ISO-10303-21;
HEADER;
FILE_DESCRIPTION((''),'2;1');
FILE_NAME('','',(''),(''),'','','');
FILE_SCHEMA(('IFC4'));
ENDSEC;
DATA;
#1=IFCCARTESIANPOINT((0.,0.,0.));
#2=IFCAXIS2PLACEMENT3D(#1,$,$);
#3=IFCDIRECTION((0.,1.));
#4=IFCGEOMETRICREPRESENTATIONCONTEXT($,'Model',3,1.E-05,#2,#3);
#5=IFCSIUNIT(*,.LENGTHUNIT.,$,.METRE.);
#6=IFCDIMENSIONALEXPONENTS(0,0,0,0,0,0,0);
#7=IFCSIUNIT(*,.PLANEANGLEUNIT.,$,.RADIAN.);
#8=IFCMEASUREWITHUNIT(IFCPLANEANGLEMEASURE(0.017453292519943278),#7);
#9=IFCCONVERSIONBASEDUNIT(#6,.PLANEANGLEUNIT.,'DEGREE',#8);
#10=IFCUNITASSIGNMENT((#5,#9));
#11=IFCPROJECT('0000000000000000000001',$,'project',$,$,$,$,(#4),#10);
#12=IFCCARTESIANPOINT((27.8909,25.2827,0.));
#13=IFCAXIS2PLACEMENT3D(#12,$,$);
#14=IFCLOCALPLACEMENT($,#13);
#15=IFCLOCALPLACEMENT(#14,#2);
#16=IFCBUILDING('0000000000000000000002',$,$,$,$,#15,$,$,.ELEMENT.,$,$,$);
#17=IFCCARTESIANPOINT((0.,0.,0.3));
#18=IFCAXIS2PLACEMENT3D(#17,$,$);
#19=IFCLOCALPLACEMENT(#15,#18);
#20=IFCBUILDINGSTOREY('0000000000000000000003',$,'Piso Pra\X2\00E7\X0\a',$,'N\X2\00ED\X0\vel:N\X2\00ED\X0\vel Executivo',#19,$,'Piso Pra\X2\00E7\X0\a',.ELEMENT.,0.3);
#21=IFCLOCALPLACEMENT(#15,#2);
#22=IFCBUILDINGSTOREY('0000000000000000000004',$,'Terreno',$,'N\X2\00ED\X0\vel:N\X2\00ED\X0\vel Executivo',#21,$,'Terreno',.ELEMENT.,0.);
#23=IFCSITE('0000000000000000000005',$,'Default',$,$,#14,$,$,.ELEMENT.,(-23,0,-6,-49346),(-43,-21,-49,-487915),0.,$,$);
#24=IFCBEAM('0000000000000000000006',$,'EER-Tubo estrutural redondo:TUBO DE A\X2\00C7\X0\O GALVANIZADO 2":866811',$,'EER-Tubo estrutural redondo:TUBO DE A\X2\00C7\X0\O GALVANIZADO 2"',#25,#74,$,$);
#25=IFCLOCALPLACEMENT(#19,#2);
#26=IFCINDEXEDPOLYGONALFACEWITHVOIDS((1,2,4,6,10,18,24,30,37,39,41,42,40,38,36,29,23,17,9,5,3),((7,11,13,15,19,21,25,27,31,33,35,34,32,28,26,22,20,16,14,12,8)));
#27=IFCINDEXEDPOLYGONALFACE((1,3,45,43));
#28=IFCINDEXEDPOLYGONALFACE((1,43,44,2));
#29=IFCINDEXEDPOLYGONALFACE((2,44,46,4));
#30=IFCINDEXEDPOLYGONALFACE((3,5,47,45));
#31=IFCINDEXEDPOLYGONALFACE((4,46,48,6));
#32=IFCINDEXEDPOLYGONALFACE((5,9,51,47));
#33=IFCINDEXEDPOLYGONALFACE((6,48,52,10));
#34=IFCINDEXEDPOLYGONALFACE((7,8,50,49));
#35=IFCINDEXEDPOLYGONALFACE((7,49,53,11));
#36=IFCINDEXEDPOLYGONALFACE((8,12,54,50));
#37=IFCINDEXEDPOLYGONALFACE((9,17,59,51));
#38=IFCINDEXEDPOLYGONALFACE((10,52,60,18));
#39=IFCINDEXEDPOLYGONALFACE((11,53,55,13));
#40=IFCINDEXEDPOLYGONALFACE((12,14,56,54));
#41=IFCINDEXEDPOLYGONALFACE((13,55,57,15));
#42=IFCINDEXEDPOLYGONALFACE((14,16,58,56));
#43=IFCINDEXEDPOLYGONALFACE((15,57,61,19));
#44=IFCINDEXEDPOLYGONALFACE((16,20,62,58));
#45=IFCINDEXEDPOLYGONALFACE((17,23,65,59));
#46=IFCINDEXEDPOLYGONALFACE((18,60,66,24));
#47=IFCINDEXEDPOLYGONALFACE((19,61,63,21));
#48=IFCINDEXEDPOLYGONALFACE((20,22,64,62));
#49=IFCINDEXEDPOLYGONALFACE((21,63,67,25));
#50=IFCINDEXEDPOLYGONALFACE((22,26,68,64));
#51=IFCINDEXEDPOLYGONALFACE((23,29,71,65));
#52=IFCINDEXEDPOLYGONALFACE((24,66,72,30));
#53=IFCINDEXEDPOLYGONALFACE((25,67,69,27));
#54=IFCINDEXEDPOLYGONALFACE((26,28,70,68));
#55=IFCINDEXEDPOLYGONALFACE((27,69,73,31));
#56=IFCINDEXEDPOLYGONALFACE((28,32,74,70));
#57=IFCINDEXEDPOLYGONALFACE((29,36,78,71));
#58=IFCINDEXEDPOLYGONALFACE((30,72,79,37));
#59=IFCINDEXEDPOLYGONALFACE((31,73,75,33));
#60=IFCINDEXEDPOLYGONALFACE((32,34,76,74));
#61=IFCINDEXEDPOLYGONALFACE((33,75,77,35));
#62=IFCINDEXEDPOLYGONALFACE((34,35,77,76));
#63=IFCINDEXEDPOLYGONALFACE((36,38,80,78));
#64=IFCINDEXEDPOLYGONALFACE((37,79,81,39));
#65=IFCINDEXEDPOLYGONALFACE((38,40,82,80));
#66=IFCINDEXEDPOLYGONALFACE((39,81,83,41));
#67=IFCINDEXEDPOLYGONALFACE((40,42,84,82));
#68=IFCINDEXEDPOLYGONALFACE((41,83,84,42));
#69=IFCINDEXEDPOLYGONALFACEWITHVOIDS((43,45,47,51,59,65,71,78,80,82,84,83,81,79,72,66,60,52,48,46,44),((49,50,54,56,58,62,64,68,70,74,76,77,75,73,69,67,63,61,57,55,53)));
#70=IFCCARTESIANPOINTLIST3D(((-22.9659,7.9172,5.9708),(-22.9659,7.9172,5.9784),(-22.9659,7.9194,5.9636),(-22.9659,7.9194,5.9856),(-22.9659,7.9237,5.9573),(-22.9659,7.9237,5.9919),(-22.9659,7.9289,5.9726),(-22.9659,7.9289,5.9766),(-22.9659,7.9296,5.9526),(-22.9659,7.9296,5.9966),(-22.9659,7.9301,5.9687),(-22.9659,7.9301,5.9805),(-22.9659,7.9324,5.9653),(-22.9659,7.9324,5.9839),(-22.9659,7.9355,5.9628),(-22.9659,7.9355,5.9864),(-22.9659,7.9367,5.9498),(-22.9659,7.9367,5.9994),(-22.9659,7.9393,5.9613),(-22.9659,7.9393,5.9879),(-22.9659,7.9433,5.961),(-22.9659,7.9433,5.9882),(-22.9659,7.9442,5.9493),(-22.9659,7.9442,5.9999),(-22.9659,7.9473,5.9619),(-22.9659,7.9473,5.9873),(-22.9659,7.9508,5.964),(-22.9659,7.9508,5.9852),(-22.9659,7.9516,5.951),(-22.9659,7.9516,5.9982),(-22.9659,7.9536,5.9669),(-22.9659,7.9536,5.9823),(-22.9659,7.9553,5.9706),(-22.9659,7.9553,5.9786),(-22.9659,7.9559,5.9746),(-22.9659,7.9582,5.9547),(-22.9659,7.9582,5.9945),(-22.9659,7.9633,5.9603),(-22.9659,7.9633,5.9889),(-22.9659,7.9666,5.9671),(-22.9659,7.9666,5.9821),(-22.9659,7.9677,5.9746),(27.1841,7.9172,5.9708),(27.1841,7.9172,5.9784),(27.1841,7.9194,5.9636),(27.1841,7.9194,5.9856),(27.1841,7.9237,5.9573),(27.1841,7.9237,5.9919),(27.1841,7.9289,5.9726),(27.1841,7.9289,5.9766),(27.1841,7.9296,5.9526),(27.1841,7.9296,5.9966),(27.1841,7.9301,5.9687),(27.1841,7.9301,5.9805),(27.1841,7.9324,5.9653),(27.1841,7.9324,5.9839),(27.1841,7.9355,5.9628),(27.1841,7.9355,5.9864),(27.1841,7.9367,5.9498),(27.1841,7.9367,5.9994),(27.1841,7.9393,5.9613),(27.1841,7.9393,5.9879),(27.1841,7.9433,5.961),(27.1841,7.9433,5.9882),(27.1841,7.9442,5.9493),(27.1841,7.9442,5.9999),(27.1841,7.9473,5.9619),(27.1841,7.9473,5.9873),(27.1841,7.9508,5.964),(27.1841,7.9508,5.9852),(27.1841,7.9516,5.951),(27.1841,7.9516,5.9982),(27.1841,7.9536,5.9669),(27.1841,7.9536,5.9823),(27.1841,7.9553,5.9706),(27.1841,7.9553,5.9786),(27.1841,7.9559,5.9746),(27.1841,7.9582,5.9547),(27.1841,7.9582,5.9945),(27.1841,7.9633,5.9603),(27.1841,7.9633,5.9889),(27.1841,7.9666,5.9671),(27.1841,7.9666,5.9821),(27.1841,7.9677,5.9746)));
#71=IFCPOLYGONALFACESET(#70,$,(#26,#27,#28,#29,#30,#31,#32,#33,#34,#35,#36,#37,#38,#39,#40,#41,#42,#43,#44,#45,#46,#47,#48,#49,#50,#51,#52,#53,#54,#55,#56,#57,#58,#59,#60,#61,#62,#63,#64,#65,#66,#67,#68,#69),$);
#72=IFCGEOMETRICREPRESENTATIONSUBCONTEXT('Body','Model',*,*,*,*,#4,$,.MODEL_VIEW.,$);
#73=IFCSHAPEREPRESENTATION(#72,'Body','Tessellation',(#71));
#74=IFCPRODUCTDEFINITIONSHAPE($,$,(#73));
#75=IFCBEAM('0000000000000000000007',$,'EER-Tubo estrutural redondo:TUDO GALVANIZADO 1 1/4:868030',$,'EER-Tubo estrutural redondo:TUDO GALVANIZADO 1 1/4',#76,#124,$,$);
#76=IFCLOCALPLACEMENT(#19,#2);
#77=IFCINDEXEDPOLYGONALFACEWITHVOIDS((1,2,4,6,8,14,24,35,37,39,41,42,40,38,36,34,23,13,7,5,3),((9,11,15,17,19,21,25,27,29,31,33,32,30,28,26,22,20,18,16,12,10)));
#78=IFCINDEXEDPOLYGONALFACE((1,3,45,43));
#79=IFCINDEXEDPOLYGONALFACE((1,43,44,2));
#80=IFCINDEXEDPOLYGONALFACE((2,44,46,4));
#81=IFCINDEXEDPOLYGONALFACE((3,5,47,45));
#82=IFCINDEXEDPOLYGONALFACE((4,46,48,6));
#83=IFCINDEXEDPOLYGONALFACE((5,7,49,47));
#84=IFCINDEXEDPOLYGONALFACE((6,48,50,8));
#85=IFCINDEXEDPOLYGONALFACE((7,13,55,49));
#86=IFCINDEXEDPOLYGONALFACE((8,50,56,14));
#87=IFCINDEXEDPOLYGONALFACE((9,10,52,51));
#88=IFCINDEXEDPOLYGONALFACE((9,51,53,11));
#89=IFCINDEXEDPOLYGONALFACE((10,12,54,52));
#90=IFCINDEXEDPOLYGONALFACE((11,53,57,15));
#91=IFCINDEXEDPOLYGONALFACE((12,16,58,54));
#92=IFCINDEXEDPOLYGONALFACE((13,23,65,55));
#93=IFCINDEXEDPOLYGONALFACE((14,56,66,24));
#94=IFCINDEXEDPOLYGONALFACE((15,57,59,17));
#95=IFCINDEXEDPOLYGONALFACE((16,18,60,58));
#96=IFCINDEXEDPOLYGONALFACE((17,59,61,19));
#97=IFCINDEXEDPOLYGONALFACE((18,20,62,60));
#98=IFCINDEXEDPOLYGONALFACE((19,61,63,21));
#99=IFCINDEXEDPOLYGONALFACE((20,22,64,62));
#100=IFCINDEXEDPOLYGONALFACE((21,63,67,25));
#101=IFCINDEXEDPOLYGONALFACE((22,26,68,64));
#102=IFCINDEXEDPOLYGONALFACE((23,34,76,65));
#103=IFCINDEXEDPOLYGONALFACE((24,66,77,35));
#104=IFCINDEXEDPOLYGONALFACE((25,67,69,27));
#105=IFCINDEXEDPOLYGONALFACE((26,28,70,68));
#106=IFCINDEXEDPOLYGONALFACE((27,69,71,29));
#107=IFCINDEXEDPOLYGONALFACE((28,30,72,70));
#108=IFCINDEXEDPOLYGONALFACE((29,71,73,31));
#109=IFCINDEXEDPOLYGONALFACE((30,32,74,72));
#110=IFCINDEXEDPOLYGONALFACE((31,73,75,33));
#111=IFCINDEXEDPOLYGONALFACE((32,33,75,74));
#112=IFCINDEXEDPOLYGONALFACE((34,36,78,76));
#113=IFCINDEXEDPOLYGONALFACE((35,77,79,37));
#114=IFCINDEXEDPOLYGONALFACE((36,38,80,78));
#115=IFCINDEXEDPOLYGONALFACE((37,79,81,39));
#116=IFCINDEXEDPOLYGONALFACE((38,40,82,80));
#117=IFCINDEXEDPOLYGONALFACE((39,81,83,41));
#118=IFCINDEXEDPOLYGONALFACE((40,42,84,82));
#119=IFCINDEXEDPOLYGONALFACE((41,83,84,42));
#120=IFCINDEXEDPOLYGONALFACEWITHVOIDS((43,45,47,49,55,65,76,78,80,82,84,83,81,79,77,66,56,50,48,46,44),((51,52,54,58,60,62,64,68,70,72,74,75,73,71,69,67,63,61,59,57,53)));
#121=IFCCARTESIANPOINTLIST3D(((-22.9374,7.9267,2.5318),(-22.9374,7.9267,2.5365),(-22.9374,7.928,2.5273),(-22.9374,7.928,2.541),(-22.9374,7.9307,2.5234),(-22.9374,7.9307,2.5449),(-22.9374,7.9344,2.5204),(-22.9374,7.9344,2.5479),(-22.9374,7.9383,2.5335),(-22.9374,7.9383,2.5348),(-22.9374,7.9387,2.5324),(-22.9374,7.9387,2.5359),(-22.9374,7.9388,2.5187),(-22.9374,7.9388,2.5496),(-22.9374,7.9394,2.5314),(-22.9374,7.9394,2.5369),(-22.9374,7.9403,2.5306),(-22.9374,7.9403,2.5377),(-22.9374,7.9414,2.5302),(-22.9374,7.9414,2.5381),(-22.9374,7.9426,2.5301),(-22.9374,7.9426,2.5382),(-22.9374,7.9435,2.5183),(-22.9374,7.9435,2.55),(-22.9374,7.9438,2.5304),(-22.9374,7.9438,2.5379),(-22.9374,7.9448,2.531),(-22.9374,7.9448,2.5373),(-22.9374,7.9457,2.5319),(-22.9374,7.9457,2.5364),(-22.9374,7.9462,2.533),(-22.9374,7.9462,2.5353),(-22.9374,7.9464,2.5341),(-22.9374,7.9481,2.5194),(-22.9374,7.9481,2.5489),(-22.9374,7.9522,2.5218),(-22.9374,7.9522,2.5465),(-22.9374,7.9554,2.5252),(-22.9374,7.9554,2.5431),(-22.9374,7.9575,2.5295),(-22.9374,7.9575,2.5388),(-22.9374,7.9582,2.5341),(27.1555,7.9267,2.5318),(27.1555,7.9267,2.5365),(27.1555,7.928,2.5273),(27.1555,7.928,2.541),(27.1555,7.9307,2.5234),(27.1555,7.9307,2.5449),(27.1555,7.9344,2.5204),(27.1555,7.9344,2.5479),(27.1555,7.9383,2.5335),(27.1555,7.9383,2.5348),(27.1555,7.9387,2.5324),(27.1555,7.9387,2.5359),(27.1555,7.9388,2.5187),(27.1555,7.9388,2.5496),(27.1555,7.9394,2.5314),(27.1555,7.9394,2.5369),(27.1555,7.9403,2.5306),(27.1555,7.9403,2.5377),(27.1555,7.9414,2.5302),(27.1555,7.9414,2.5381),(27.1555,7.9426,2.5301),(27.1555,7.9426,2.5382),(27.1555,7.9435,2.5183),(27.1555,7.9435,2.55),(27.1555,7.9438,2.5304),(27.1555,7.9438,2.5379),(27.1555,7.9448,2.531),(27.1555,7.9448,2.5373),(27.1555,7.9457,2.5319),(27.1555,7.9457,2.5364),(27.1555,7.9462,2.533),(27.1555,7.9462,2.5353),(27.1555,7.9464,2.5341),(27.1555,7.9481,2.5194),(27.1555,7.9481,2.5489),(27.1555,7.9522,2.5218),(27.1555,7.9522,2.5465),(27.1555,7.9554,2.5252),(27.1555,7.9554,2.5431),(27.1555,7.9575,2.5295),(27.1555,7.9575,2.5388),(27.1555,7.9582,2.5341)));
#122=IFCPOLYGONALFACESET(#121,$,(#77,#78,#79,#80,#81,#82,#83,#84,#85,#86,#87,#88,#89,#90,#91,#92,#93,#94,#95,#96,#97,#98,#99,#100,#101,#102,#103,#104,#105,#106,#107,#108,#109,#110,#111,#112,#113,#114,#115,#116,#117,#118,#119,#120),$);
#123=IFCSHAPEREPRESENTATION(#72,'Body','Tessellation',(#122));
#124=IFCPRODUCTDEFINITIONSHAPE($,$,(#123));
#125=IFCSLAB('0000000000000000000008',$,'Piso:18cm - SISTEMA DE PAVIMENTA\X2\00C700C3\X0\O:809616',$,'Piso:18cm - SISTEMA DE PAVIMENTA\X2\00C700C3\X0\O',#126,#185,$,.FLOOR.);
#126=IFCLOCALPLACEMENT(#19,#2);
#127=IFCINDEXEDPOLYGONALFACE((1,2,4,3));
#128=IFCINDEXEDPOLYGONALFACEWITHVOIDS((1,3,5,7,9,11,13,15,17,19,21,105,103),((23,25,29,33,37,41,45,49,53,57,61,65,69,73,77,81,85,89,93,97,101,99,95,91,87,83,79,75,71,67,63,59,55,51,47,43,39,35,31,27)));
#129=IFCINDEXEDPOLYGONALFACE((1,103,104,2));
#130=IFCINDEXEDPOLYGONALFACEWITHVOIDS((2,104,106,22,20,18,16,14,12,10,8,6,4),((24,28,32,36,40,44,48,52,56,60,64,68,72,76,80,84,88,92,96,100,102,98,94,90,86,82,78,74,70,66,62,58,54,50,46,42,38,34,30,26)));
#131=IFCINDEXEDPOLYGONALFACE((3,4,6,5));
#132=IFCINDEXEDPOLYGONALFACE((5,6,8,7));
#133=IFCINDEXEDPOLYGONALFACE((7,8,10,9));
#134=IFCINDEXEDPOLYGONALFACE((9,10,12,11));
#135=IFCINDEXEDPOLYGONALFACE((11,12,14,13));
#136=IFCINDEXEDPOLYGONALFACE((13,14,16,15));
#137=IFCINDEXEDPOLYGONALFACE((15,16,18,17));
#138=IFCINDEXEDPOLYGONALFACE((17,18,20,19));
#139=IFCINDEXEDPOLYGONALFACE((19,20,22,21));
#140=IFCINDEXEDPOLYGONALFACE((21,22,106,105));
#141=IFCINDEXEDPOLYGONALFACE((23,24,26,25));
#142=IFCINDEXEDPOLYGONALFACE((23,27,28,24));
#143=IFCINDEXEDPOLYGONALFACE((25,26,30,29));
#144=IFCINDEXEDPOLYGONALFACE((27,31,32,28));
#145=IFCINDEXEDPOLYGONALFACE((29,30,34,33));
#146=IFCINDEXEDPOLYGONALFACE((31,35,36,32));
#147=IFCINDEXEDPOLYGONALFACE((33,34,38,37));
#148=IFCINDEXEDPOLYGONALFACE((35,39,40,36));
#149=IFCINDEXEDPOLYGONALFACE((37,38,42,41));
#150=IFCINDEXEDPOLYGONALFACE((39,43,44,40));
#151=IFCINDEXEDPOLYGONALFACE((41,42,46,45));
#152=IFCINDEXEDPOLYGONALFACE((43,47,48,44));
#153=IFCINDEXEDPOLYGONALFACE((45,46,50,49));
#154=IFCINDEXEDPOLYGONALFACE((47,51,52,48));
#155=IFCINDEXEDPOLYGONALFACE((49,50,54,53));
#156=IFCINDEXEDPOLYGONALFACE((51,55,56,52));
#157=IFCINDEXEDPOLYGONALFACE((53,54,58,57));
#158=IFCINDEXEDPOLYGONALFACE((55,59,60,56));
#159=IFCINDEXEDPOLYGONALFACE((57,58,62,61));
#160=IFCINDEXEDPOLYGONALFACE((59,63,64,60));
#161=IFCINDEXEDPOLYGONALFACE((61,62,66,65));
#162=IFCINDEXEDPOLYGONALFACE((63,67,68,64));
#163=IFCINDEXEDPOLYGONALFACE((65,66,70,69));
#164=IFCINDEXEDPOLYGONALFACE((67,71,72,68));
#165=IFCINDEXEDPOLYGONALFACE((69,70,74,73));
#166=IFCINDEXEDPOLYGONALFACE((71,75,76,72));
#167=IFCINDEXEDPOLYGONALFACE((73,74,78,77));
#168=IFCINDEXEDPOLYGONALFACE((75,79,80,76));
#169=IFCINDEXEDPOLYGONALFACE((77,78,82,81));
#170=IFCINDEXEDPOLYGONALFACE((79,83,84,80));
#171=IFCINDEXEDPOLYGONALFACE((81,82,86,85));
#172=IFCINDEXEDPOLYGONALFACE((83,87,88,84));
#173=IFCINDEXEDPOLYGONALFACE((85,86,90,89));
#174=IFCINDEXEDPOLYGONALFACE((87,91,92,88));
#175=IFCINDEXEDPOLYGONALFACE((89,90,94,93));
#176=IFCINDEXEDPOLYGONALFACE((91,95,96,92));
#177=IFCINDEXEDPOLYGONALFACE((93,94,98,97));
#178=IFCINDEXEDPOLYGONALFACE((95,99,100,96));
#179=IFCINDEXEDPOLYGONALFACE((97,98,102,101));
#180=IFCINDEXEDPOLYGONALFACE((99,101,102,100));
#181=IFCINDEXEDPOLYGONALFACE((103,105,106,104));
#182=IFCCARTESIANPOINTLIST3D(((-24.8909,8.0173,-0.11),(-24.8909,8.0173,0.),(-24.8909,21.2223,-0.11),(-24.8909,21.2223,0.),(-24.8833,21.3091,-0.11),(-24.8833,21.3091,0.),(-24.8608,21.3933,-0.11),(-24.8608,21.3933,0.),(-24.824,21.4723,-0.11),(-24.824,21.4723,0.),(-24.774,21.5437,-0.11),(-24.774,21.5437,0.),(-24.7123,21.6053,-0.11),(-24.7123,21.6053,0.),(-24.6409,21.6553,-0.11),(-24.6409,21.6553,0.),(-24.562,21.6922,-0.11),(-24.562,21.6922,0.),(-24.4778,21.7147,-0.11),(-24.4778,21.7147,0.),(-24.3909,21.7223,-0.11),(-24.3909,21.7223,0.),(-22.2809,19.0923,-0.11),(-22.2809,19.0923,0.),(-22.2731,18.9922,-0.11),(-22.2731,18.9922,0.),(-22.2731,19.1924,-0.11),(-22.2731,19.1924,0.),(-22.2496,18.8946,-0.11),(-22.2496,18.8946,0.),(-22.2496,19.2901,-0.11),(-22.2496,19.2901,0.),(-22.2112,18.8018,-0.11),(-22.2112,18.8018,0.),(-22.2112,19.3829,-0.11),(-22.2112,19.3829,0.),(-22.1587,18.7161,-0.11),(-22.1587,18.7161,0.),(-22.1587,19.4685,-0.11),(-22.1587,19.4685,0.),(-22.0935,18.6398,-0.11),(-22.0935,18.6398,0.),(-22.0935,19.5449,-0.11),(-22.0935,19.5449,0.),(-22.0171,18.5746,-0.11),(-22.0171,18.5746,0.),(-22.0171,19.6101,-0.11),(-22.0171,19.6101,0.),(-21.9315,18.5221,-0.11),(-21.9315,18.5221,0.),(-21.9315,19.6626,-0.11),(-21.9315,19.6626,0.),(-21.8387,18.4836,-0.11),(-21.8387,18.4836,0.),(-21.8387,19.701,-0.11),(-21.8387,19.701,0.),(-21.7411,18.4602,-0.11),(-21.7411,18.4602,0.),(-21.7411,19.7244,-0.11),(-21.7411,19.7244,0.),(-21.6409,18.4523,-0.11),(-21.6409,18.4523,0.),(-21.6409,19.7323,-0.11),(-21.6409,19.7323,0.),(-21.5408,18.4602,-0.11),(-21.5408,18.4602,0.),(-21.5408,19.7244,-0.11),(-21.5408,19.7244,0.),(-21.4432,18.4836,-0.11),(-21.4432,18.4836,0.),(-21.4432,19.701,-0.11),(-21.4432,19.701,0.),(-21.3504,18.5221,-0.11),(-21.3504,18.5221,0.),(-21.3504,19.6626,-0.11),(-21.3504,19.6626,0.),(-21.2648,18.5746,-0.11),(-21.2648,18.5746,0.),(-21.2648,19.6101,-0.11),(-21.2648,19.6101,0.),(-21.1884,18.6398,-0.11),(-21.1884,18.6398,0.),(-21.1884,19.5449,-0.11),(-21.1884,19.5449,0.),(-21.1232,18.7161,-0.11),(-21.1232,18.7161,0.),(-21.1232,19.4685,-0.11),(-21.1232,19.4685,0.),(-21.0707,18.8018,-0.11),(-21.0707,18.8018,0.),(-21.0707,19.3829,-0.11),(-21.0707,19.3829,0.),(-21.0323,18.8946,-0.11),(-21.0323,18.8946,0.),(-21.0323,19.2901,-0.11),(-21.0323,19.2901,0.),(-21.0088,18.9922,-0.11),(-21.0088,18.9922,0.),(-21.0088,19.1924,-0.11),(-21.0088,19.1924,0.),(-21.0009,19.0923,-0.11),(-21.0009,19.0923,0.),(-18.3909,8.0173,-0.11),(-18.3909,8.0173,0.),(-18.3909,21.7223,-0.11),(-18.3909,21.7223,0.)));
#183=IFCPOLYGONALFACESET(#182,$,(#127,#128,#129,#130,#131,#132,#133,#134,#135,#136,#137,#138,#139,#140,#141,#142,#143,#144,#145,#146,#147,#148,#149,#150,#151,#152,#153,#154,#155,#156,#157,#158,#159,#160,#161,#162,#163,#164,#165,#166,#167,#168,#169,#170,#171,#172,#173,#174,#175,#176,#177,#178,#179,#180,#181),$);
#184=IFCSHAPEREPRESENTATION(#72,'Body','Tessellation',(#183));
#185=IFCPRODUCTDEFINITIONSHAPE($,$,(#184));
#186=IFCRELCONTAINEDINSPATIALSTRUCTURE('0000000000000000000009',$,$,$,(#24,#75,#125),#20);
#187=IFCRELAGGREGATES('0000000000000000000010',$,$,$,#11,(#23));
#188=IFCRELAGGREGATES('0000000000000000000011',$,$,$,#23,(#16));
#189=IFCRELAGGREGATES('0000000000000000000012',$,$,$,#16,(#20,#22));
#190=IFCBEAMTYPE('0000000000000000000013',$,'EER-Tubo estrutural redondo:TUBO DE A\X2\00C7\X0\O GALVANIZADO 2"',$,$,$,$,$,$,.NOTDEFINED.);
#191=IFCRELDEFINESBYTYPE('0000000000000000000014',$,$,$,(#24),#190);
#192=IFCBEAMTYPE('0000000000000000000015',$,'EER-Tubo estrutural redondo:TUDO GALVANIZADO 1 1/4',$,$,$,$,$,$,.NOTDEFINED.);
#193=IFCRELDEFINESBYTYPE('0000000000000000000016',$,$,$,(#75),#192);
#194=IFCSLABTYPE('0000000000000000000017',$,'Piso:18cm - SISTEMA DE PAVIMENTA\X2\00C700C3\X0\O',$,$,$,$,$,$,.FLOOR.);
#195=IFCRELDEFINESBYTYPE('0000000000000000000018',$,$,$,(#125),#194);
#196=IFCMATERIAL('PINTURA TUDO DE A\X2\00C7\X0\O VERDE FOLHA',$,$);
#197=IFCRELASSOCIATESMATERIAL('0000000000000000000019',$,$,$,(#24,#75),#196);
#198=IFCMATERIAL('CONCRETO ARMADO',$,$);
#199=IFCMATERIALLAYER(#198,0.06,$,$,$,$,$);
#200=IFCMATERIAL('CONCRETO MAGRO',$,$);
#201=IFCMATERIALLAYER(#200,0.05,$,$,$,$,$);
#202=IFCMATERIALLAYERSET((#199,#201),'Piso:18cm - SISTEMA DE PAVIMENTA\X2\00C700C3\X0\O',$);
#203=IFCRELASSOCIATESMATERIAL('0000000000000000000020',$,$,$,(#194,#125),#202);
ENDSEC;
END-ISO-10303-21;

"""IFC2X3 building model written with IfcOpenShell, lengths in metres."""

from ifc_helpers import new_model, entity, si_unit, converted_unit, direction, frame, frame_2d, origin, origin_2d_with_axis, place, context, subcontext, project, spatial, polyline, circle_curve, parameter, trimmed, segment, composite_curve, circle, hollow_circle, outline, extrude, material, layer, layer_set, layer_usage, type_object, element, save


model = new_model("IFC2X3")

# Units and contexts
model_context = context("Model", 3, precision=1e-05, world=origin(), true_north=direction((0.0, 1.0)))
body_context = subcontext(model_context, "Body", "Model", "MODEL_VIEW")
ifc_project = project(units=[si_unit("LENGTHUNIT", "METRE"), converted_unit("PLANEANGLEUNIT", "DEGREE", entity("IfcPlaneAngleMeasure", 0.017453292519943278), si_unit("PLANEANGLEUNIT", "RADIAN"), dimensions=[0, 0, 0, 0, 0, 0, 0])], contexts=[model_context])

# Site, building, storey
site_placement = place(None, frame((27.8909, 25.2827, 0.0)))
site = spatial("IfcSite", under=ifc_project, at=site_placement, Name="Default", CompositionType="ELEMENT", RefLatitude=(-23, 0, -6, -49346), RefLongitude=(-43, -21, -49, -487915), RefElevation=0.0)
building_placement = place(site_placement, origin())
building = spatial("IfcBuilding", under=site, at=building_placement, CompositionType="ELEMENT")
storey_1_placement = place(building_placement, frame((0.0, 0.0, 0.3)))
storey_1 = spatial("IfcBuildingStorey", under=building, at=storey_1_placement, Name="Piso Praça", ObjectType="Nível:Nível Executivo", LongName="Piso Praça", CompositionType="ELEMENT", Elevation=0.3)

# Shared definitions
ifc_material_1 = material(Name="PINTURA TUDO DE AÇO VERDE FOLHA")

# Beams
beam_type_1 = type_object("IfcBeamType", Name="EER-Tubo estrutural redondo:TUBO DE AÇO GALVANIZADO 2\"", PredefinedType="NOTDEFINED")
beam_1_placement = place(storey_1_placement, frame((-22.9659, 7.9423, 6.0)))
element("IfcBeam", 1, at=beam_1_placement, inside=storey_1, type_object=beam_type_1, material=ifc_material_1, Name="EER-Tubo estrutural redondo:TUBO DE AÇO GALVANIZADO 2\":866811", ObjectType="EER-Tubo estrutural redondo:TUBO DE AÇO GALVANIZADO 2\"", context=body_context, shape_type="SweptSolid", body=[
    extrude(hollow_circle(Radius=0.0254, WallThickness=0.0118, at=origin_2d_with_axis()), frame((0.0, 0.0, -0.0254), z_axis=(1.0, 0.0, 0.0), x_axis=(0.0, 1.0, 0.0)), (0.0, 0.0, 1.0), 50.15),
])
beam_type_2 = type_object("IfcBeamType", Name="EER-Tubo estrutural redondo:TUDO GALVANIZADO 1 1/4", PredefinedType="NOTDEFINED")
beam_2_placement = place(storey_1_placement, frame((-22.9659, 7.9423, 2.55)))
element("IfcBeam", 2, at=beam_2_placement, inside=storey_1, type_object=beam_type_2, material=ifc_material_1, Name="EER-Tubo estrutural redondo:TUDO GALVANIZADO 1 1/4:868030", ObjectType="EER-Tubo estrutural redondo:TUDO GALVANIZADO 1 1/4", context=body_context, shape_type="SweptSolid", body=[
    extrude(hollow_circle(Radius=0.0159, WallThickness=0.0118, at=origin_2d_with_axis()), frame((0.0286, 0.0, -0.0159), z_axis=(1.0, 0.0, 0.0), x_axis=(0.0, 1.0, 0.0)), (0.0, 0.0, 1.0), 50.0929),
])

# Slab, opening
ifc_material_2 = material(Name="CONCRETO ARMADO")
ifc_layer_1 = layer(ifc_material_2, 0.06)
ifc_material_3 = material(Name="CONCRETO MAGRO")
ifc_layer_2 = layer(ifc_material_3, 0.05)
ifc_layer_set_1 = layer_set([ifc_layer_1, ifc_layer_2], Name="Piso:18cm - SISTEMA DE PAVIMENTAÇÃO")
ifc_layer_usage_1 = layer_usage(ifc_layer_set_1, "AXIS3", "POSITIVE", 0.0)
slab_type = type_object("IfcSlabType", Name="Piso:18cm - SISTEMA DE PAVIMENTAÇÃO", PredefinedType="FLOOR", material=ifc_layer_set_1)
slab_placement = place(storey_1_placement, frame((-24.8909, 8.0173, -0.11)))
slab = element("IfcSlab", 3, at=slab_placement, inside=storey_1, type_object=slab_type, material=ifc_layer_usage_1, Name="Piso:18cm - SISTEMA DE PAVIMENTAÇÃO:809616", ObjectType="Piso:18cm - SISTEMA DE PAVIMENTAÇÃO", PredefinedType="FLOOR", context=body_context, shape_type="SweptSolid", body=[
    extrude(outline(composite_curve([segment(trimmed(circle_curve(frame_2d((2.75, 6.3525), x_axis=(-1.0, 0.0)), 0.5), [parameter(180.0)], [parameter(270.0)], True, "PARAMETER"), True, "CONTINUOUS"), segment(polyline([(2.75, 6.8525), (-3.25, 6.8525)]), True, "CONTINUOUS"), segment(polyline([(-3.25, 6.8525), (-3.25, -6.8525)]), True, "CONTINUOUS"), segment(polyline([(-3.25, -6.8525), (3.25, -6.8525)]), True, "CONTINUOUS"), segment(polyline([(3.25, -6.8525), (3.25, 6.3525)]), True, "CONTINUOUS")], self_intersect=False)), frame((3.25, 6.8525, 0.11), z_axis=(0.0, 0.0, -1.0), x_axis=(-1.0, 0.0, 0.0)), (0.0, 0.0, 1.0), 0.11),
])
opening_1_placement = place(slab_placement, origin())
element("IfcOpeningElement", 4, at=opening_1_placement, cuts=slab, ObjectType="Opening", context=body_context, shape_type="SweptSolid", body=[
    extrude(circle(Radius=0.64, at=origin_2d_with_axis()), frame((3.25, 11.075, 0.11), z_axis=(0.0, 0.0, -1.0), x_axis=(1.0, 0.0, 0.0)), (0.0, 0.0, 1.0), 0.11),
])

# Shared definitions
storey_2_placement = place(building_placement, origin())
storey_2 = spatial("IfcBuildingStorey", under=building, at=storey_2_placement, Name="Terreno", ObjectType="Nível:Nível Executivo", LongName="Terreno", CompositionType="ELEMENT", Elevation=0.0)

save(model, "model.ifc")
